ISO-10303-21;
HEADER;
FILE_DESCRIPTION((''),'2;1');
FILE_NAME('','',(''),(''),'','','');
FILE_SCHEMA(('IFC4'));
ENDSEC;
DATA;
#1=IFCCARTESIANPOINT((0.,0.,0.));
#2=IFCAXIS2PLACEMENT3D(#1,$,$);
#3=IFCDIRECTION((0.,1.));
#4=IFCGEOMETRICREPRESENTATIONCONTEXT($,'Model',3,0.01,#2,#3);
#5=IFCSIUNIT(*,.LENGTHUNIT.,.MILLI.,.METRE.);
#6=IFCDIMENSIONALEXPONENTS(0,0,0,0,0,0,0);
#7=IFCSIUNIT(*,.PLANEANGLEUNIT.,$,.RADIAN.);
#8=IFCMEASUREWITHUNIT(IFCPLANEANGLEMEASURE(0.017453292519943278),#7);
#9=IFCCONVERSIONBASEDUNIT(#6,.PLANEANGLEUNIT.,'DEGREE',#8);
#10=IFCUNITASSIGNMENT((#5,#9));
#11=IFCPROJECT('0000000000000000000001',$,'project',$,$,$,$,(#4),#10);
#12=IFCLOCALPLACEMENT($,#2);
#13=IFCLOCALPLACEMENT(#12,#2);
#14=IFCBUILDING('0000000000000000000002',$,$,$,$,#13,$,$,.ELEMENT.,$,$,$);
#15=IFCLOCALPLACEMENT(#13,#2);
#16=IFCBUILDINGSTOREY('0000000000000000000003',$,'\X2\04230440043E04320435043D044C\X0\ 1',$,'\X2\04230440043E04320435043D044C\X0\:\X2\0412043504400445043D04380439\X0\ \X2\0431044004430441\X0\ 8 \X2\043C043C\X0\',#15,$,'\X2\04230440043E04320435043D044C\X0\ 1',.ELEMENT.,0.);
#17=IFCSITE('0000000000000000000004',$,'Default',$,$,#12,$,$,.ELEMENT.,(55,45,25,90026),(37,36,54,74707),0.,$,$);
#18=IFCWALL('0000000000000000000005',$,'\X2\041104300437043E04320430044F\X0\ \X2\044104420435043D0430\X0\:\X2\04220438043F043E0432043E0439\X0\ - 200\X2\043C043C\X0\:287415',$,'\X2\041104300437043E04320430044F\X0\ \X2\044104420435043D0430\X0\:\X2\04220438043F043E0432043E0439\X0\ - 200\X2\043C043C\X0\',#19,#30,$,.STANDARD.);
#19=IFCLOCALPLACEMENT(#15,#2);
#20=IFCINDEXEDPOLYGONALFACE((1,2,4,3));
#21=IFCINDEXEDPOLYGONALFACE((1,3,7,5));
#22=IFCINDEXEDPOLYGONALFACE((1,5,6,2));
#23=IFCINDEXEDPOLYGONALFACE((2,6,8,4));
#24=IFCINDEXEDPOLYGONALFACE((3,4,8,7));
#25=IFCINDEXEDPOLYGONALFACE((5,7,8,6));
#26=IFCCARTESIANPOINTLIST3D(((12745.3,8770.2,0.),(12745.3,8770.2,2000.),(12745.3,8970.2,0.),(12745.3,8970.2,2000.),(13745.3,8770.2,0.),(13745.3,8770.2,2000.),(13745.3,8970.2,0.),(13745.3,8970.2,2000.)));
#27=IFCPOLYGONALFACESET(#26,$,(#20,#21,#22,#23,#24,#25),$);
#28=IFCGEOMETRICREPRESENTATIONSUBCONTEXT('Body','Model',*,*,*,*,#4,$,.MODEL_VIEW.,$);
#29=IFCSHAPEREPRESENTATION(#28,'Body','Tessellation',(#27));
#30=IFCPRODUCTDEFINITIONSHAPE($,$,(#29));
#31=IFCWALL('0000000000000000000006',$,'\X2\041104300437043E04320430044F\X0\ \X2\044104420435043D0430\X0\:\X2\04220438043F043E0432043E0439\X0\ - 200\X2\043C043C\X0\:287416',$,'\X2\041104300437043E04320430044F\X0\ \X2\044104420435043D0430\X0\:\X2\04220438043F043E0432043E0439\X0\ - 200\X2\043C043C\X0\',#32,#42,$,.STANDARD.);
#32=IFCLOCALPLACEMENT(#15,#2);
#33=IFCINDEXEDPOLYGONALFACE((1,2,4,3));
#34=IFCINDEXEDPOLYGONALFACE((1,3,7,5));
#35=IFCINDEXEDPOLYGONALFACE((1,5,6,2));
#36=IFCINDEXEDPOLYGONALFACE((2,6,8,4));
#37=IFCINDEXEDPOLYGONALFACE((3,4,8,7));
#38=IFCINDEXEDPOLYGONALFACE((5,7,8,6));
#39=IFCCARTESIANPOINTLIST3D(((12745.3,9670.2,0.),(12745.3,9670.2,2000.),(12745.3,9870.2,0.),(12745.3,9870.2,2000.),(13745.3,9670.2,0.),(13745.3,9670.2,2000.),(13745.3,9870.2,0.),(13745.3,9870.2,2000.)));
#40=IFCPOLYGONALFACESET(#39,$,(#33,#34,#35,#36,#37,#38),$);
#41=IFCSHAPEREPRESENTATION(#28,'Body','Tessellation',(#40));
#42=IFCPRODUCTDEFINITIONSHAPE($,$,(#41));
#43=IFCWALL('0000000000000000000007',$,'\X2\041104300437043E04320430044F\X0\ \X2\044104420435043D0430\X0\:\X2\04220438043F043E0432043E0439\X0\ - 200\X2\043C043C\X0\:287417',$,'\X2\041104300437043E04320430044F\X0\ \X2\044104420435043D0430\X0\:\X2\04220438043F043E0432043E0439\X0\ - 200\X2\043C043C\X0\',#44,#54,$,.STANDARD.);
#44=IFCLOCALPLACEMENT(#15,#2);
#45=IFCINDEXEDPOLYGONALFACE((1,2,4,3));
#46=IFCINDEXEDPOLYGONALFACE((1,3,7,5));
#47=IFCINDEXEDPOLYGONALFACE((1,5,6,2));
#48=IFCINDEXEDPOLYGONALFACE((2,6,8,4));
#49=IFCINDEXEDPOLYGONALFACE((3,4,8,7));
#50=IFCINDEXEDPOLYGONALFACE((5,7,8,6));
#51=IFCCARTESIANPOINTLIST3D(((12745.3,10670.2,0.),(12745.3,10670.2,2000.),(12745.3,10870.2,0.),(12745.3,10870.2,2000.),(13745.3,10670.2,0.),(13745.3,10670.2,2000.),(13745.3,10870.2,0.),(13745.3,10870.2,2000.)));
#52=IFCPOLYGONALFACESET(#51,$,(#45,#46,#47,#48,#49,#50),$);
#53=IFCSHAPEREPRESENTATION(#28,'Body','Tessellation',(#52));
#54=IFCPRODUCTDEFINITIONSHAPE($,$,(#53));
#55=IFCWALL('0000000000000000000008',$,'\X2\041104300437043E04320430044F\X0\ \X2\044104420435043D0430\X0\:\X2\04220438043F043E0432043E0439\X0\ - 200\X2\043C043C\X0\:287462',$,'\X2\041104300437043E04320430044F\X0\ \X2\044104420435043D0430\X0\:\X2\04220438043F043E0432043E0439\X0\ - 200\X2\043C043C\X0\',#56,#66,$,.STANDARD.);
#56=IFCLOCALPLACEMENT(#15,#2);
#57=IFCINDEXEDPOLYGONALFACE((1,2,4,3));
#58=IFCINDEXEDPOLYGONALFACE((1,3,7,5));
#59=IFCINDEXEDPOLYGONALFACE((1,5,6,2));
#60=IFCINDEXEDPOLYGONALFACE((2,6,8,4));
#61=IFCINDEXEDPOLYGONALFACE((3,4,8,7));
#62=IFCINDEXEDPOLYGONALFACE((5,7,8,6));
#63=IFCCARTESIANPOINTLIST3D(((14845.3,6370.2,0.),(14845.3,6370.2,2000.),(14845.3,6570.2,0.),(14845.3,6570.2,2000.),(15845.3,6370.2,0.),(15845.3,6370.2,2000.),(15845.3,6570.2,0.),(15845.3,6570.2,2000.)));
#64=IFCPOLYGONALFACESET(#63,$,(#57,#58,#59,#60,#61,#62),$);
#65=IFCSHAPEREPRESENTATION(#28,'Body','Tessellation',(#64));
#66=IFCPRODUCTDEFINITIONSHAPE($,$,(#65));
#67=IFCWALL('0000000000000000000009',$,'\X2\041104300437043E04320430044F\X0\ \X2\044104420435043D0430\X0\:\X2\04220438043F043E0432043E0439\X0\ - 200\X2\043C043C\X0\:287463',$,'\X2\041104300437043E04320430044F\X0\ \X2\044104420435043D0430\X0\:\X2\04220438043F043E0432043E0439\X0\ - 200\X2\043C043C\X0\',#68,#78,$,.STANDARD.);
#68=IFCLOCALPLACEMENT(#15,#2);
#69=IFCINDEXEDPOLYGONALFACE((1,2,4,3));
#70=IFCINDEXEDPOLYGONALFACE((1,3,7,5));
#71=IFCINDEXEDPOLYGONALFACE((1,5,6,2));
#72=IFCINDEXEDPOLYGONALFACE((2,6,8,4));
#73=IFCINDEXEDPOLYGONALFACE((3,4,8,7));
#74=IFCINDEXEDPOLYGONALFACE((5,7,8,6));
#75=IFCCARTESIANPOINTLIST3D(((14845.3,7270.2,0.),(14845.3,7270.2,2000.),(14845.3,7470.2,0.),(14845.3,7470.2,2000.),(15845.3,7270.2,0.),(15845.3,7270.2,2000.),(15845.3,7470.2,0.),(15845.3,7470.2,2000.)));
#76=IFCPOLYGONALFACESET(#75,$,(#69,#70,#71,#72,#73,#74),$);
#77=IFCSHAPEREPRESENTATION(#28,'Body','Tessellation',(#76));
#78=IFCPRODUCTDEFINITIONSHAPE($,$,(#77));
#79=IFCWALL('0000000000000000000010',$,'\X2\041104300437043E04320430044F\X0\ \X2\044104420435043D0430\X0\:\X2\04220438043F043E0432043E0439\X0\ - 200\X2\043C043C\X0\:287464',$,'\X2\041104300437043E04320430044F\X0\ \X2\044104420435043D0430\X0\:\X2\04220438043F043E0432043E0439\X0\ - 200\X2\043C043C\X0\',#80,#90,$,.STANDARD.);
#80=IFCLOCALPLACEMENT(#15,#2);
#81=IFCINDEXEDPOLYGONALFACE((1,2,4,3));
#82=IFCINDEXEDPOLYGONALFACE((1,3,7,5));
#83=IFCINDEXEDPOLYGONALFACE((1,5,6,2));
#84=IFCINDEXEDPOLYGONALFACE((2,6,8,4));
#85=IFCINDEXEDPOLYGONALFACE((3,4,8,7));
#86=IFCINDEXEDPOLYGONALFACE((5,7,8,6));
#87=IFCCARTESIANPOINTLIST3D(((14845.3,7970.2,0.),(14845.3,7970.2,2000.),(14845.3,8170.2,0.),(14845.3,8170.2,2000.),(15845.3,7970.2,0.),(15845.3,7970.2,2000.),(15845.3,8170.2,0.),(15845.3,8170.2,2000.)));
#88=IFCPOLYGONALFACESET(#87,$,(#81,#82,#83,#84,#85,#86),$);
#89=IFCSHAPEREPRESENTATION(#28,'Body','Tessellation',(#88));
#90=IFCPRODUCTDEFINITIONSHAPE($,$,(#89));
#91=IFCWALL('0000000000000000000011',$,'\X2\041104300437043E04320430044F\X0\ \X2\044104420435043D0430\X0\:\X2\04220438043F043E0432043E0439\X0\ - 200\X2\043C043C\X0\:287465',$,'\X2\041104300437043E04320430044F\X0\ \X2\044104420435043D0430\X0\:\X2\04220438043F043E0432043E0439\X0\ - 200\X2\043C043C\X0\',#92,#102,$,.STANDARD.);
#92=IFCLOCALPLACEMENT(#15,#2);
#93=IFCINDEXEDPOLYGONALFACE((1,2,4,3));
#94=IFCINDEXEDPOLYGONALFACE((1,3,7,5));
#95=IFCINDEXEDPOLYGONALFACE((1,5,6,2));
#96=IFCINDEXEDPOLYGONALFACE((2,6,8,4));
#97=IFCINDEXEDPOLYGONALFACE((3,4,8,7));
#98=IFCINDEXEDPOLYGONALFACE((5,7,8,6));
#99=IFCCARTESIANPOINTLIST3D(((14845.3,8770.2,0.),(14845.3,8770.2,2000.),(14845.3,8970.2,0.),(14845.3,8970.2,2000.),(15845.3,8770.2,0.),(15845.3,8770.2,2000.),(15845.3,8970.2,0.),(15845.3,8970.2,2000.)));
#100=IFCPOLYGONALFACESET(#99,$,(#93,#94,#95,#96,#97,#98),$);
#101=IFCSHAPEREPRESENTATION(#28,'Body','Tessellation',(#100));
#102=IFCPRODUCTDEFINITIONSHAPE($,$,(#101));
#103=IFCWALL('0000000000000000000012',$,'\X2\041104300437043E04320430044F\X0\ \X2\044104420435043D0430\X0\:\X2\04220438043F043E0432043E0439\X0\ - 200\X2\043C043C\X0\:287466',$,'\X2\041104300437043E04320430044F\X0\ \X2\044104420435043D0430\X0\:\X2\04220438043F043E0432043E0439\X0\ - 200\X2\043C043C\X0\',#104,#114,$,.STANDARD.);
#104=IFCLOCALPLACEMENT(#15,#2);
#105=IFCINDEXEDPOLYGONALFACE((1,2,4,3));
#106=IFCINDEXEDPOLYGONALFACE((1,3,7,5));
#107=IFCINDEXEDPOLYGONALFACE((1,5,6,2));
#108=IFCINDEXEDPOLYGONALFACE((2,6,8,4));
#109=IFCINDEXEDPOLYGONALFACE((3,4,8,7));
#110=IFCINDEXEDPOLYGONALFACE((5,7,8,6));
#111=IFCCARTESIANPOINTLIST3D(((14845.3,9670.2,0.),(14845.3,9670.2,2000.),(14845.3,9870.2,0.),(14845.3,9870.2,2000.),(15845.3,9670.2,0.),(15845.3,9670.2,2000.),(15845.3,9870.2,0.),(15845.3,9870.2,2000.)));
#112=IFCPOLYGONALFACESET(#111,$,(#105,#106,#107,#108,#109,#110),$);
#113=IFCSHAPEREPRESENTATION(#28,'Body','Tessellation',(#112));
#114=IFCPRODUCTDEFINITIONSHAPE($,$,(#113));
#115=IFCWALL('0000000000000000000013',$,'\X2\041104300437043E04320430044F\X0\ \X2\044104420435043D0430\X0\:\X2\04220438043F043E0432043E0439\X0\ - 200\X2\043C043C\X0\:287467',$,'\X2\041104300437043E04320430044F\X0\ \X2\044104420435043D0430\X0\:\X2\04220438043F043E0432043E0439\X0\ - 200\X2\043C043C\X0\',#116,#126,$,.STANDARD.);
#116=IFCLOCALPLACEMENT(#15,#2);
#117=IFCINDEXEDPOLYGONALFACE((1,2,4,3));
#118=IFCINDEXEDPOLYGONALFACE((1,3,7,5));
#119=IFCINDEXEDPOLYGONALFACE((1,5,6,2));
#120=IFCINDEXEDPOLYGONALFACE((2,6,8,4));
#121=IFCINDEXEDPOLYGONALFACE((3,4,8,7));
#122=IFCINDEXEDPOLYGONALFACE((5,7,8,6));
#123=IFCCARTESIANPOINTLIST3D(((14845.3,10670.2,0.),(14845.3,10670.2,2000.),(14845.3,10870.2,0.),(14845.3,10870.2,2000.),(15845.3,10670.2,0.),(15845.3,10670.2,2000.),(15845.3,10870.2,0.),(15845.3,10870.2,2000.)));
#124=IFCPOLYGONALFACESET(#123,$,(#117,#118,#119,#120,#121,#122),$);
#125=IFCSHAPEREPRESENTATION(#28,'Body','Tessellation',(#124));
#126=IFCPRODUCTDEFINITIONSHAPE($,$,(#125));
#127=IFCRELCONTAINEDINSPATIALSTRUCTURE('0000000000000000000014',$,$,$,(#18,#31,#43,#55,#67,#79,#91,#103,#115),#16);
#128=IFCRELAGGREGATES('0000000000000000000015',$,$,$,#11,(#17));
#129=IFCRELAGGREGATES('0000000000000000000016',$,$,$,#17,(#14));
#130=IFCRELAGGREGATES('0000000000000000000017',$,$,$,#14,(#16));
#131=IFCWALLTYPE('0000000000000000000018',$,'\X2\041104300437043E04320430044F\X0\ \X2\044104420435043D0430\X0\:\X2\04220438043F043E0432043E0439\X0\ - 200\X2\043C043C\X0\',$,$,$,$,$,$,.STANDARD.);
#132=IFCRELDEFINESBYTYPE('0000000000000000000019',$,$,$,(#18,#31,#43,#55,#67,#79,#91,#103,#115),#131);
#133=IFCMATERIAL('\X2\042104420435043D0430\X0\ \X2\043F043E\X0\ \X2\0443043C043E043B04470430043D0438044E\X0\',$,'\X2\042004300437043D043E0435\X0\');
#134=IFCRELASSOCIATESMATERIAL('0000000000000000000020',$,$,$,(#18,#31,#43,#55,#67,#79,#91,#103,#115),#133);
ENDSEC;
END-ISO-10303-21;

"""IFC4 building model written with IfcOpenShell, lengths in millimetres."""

from ifc_helpers import new_model, entity, si_unit, converted_unit, direction, frame, origin, place, context, subcontext, project, spatial, indexed_curve, outline, extrude, material, type_object, element, save


model = new_model("IFC4")

# Units and contexts
model_context = context("Model", 3, precision=0.01, world=origin(), true_north=direction((0.0, 1.0)))
body_context = subcontext(model_context, "Body", "Model", "MODEL_VIEW")
ifc_project = project(units=[si_unit("LENGTHUNIT", "METRE", prefix="MILLI"), converted_unit("PLANEANGLEUNIT", "DEGREE", entity("IfcPlaneAngleMeasure", 0.017453292519943278), si_unit("PLANEANGLEUNIT", "RADIAN"), dimensions=[0, 0, 0, 0, 0, 0, 0])], contexts=[model_context])

# Site, building, storey
site_placement = place(None, origin())
site = spatial("IfcSite", under=ifc_project, at=site_placement, Name="Default", CompositionType="ELEMENT", RefLatitude=(55, 45, 25, 90026), RefLongitude=(37, 36, 54, 74707), RefElevation=0.0)
building_placement = place(site_placement, origin())
building = spatial("IfcBuilding", under=site, at=building_placement, CompositionType="ELEMENT")
storey_placement = place(building_placement, origin())
storey = spatial("IfcBuildingStorey", under=building, at=storey_placement, Name="Уровень 1", ObjectType="Уровень:Верхний брус 8 мм", LongName="Уровень 1", CompositionType="ELEMENT", Elevation=0.0)

# Walls
ifc_material = material(Name="Стена по умолчанию", Category="Разное")
wall_type = type_object("IfcWallType", Name="Базовая стена:Типовой - 200мм", PredefinedType="STANDARD")
wall_1_placement = place(storey_placement, frame((12745.3, 8870.2, 0.0)))
element("IfcWall", 1, at=wall_1_placement, inside=storey, type_object=wall_type, material=ifc_material, Name="Базовая стена:Типовой - 200мм:287415", ObjectType="Базовая стена:Типовой - 200мм", PredefinedType="STANDARD", context=body_context, shape_type="SweptSolid", body=[
    extrude(outline(indexed_curve([(1000.0, 100.0), (0.0, 100.0), (0.0, -100.0), (1000.0, -100.0), (1000.0, 100.0)], self_intersect=False)), origin(), (0.0, 0.0, 1.0), 2000.0),
])
wall_2_placement = place(storey_placement, frame((12745.3, 9770.2, 0.0)))
element("IfcWall", 2, at=wall_2_placement, inside=storey, type_object=wall_type, material=ifc_material, Name="Базовая стена:Типовой - 200мм:287416", ObjectType="Базовая стена:Типовой - 200мм", PredefinedType="STANDARD", context=body_context, shape_type="SweptSolid", body=[
    extrude(outline(indexed_curve([(1000.0, 100.0), (0.0, 100.0), (0.0, -100.0), (1000.0, -100.0), (1000.0, 100.0)], self_intersect=False)), origin(), (0.0, 0.0, 1.0), 2000.0),
])
wall_3_placement = place(storey_placement, frame((12745.3, 10770.2, 0.0)))
element("IfcWall", 3, at=wall_3_placement, inside=storey, type_object=wall_type, material=ifc_material, Name="Базовая стена:Типовой - 200мм:287417", ObjectType="Базовая стена:Типовой - 200мм", PredefinedType="STANDARD", context=body_context, shape_type="SweptSolid", body=[
    extrude(outline(indexed_curve([(1000.0, 100.0), (0.0, 100.0), (0.0, -100.0), (1000.0, -100.0), (1000.0, 100.0)], self_intersect=False)), origin(), (0.0, 0.0, 1.0), 2000.0),
])
wall_4_placement = place(storey_placement, frame((14845.3, 6470.2, 0.0)))
element("IfcWall", 4, at=wall_4_placement, inside=storey, type_object=wall_type, material=ifc_material, Name="Базовая стена:Типовой - 200мм:287462", ObjectType="Базовая стена:Типовой - 200мм", PredefinedType="STANDARD", context=body_context, shape_type="SweptSolid", body=[
    extrude(outline(indexed_curve([(1000.0, 100.0), (0.0, 100.0), (0.0, -100.0), (1000.0, -100.0), (1000.0, 100.0)], self_intersect=False)), origin(), (0.0, 0.0, 1.0), 2000.0),
])
wall_5_placement = place(storey_placement, frame((14845.3, 7370.2, 0.0)))
element("IfcWall", 5, at=wall_5_placement, inside=storey, type_object=wall_type, material=ifc_material, Name="Базовая стена:Типовой - 200мм:287463", ObjectType="Базовая стена:Типовой - 200мм", PredefinedType="STANDARD", context=body_context, shape_type="SweptSolid", body=[
    extrude(outline(indexed_curve([(1000.0, 100.0), (0.0, 100.0), (0.0, -100.0), (1000.0, -100.0), (1000.0, 100.0)], self_intersect=False)), origin(), (0.0, 0.0, 1.0), 2000.0),
])
wall_6_placement = place(storey_placement, frame((14845.3, 8070.2, 0.0)))
element("IfcWall", 6, at=wall_6_placement, inside=storey, type_object=wall_type, material=ifc_material, Name="Базовая стена:Типовой - 200мм:287464", ObjectType="Базовая стена:Типовой - 200мм", PredefinedType="STANDARD", context=body_context, shape_type="SweptSolid", body=[
    extrude(outline(indexed_curve([(1000.0, 100.0), (0.0, 100.0), (0.0, -100.0), (1000.0, -100.0), (1000.0, 100.0)], self_intersect=False)), origin(), (0.0, 0.0, 1.0), 2000.0),
])
wall_7_placement = place(storey_placement, frame((14845.3, 8870.2, 0.0)))
element("IfcWall", 7, at=wall_7_placement, inside=storey, type_object=wall_type, material=ifc_material, Name="Базовая стена:Типовой - 200мм:287465", ObjectType="Базовая стена:Типовой - 200мм", PredefinedType="STANDARD", context=body_context, shape_type="SweptSolid", body=[
    extrude(outline(indexed_curve([(1000.0, 100.0), (0.0, 100.0), (0.0, -100.0), (1000.0, -100.0), (1000.0, 100.0)], self_intersect=False)), origin(), (0.0, 0.0, 1.0), 2000.0),
])
wall_8_placement = place(storey_placement, frame((14845.3, 9770.2, 0.0)))
element("IfcWall", 8, at=wall_8_placement, inside=storey, type_object=wall_type, material=ifc_material, Name="Базовая стена:Типовой - 200мм:287466", ObjectType="Базовая стена:Типовой - 200мм", PredefinedType="STANDARD", context=body_context, shape_type="SweptSolid", body=[
    extrude(outline(indexed_curve([(1000.0, 100.0), (0.0, 100.0), (0.0, -100.0), (1000.0, -100.0), (1000.0, 100.0)], self_intersect=False)), origin(), (0.0, 0.0, 1.0), 2000.0),
])
wall_9_placement = place(storey_placement, frame((14845.3, 10770.2, 0.0)))
element("IfcWall", 9, at=wall_9_placement, inside=storey, type_object=wall_type, material=ifc_material, Name="Базовая стена:Типовой - 200мм:287467", ObjectType="Базовая стена:Типовой - 200мм", PredefinedType="STANDARD", context=body_context, shape_type="SweptSolid", body=[
    extrude(outline(indexed_curve([(1000.0, 100.0), (0.0, 100.0), (0.0, -100.0), (1000.0, -100.0), (1000.0, 100.0)], self_intersect=False)), origin(), (0.0, 0.0, 1.0), 2000.0),
])

save(model, "model.ifc")
